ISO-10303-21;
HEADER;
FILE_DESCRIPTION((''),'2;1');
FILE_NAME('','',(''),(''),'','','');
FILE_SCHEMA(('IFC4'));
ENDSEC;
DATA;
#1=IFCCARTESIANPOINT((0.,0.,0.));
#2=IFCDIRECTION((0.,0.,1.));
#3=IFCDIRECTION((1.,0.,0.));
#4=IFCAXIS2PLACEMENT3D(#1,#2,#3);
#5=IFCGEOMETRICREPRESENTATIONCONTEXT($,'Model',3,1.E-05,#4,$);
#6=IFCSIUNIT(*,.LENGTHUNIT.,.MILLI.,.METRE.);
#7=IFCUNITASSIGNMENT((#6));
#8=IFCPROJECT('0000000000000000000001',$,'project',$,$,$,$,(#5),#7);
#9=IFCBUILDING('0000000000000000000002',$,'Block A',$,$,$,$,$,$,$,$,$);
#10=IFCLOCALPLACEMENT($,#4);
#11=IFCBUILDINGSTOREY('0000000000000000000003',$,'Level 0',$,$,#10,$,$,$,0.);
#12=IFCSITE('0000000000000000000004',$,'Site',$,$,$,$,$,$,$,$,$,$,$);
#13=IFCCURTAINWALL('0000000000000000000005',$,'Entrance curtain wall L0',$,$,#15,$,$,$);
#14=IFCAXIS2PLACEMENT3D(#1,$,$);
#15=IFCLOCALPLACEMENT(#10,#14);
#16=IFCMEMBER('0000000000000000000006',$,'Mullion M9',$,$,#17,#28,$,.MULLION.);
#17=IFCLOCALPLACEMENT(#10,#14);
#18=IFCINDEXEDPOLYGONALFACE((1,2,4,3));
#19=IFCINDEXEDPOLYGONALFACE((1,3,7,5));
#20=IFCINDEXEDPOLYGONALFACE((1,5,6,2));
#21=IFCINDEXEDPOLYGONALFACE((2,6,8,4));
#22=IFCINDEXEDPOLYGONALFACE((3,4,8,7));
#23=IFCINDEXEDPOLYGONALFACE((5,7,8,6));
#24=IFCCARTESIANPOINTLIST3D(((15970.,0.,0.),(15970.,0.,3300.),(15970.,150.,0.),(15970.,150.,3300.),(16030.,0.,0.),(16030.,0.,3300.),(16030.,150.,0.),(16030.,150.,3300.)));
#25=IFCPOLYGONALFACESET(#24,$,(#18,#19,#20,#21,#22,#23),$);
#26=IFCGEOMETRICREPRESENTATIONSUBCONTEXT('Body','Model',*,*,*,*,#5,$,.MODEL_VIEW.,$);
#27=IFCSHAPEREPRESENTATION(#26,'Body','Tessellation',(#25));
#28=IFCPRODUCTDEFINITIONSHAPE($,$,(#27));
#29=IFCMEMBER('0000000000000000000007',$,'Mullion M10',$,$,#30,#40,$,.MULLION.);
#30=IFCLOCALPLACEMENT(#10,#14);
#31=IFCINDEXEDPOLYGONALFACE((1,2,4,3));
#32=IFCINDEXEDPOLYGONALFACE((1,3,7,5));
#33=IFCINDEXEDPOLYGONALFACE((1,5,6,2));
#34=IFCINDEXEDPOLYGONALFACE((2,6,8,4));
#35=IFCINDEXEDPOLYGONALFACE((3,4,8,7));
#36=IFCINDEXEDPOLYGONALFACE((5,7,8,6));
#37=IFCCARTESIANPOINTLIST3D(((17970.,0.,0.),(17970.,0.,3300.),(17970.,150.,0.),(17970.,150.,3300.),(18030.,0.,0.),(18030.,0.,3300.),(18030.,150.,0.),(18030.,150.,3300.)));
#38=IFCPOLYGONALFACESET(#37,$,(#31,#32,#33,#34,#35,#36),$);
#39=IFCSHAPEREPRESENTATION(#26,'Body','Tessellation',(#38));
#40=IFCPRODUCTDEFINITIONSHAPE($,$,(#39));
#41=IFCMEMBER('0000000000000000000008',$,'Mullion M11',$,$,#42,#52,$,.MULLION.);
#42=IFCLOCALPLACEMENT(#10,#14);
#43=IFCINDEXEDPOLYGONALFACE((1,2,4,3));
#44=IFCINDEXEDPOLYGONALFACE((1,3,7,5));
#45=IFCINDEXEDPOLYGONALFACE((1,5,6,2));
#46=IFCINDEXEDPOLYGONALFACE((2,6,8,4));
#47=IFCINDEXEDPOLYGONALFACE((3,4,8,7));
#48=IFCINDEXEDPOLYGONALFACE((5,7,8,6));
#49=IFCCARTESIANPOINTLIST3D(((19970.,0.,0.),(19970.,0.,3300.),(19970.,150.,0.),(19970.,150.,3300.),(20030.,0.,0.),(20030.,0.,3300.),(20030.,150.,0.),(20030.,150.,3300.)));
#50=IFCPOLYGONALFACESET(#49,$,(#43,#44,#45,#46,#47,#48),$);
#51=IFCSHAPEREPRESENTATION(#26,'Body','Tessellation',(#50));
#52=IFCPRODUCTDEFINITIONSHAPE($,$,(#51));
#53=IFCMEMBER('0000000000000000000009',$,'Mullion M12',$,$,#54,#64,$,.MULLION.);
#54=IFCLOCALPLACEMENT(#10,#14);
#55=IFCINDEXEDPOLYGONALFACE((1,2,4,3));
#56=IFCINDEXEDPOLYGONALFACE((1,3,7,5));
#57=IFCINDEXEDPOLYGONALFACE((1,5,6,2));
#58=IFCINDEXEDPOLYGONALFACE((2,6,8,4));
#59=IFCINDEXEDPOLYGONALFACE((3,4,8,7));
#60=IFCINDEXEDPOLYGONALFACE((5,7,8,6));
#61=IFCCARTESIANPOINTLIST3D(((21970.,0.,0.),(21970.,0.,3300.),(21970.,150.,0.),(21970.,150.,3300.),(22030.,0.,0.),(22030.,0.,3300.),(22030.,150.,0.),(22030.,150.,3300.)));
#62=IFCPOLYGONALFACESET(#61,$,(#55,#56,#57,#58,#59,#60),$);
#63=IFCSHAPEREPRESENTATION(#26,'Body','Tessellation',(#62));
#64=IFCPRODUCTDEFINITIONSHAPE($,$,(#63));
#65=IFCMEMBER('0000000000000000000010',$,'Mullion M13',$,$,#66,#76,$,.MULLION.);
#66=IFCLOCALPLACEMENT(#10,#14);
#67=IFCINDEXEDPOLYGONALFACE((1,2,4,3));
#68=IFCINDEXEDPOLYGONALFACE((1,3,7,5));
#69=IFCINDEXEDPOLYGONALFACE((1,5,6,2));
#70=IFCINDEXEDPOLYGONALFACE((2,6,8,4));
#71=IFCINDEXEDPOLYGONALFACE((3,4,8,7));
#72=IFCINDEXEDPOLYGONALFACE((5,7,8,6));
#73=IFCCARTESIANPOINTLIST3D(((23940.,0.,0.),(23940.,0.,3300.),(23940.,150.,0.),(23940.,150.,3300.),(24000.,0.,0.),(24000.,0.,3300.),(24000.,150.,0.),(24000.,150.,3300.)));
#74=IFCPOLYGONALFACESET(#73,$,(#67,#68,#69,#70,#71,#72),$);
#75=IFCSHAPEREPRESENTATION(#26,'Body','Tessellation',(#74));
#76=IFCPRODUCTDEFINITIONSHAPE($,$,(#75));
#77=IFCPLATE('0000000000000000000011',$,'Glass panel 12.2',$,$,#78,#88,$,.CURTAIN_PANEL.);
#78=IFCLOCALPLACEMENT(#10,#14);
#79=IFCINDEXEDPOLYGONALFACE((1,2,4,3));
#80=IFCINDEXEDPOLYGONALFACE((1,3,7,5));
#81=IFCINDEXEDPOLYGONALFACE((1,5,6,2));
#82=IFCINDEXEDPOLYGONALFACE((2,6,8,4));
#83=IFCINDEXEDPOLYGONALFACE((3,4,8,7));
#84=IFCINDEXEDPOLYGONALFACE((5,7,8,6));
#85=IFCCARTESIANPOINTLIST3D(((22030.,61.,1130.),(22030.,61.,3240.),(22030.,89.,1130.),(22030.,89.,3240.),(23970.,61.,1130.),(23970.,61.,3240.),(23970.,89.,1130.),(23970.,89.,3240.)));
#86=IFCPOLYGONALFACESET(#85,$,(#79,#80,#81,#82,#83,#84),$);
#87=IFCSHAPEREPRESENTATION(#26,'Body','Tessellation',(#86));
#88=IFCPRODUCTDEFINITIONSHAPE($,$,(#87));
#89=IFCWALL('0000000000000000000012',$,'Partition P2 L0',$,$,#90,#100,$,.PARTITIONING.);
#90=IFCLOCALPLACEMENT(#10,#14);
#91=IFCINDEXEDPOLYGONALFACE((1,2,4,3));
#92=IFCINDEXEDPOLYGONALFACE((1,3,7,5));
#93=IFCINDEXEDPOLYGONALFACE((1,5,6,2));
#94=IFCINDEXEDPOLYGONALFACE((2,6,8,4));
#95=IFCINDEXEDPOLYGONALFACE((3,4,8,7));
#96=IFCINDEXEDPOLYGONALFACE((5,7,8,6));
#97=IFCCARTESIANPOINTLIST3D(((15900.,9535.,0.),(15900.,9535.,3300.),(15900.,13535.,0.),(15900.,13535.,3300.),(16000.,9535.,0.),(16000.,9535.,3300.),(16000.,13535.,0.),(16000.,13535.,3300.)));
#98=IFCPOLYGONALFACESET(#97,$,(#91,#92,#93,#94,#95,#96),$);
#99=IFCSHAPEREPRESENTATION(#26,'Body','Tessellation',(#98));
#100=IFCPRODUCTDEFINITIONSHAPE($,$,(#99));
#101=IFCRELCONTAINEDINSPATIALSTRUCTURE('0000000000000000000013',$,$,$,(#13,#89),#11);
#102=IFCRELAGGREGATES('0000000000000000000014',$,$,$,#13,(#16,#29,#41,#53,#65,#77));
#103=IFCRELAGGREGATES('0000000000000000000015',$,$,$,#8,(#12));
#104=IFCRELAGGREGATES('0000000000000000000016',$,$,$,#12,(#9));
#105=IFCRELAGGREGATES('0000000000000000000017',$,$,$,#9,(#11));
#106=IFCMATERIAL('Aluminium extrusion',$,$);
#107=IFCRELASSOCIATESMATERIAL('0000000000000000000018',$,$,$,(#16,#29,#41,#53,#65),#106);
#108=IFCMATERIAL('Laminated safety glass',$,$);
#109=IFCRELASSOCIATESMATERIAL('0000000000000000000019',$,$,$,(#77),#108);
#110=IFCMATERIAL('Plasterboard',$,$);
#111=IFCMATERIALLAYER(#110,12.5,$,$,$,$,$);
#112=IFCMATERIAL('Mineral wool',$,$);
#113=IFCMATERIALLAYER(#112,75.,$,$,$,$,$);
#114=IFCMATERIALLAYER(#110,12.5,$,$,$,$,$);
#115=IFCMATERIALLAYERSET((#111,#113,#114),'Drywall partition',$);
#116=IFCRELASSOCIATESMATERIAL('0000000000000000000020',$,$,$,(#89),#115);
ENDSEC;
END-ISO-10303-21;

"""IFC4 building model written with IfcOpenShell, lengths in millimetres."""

from ifc_helpers import new_model, si_unit, frame, origin_with_axes, place, context, subcontext, project, spatial, indexed_curve, rectangle, outline, extrude, material, layer, layer_set, layer_usage, element, aggregate, save


model = new_model("IFC4")

# Units and contexts
model_context = context("Model", 3, precision=1e-05, world=origin_with_axes())
body_context = subcontext(model_context, "Body", "Model", "MODEL_VIEW")
ifc_project = project(units=[si_unit("LENGTHUNIT", "METRE", prefix="MILLI")], contexts=[model_context])

# Site, building, storey
site = spatial("IfcSite", under=ifc_project, Name="Site")
building = spatial("IfcBuilding", under=site, Name="Block A")
storey_placement = place(None, origin_with_axes())
storey = spatial("IfcBuildingStorey", under=building, at=storey_placement, Name="Level 0", Elevation=0.0)

# Curtain wall, members, plate
curtain_wall_placement = place(storey_placement, origin_with_axes())
curtain_wall = element("IfcCurtainWall", 1, at=curtain_wall_placement, inside=storey, Name="Entrance curtain wall L0")
ifc_material_1 = material(Name="Aluminium extrusion")
member_1_placement = place(curtain_wall_placement, frame((16000.0, 75.0, 0.0), z_axis=(0.0, 0.0, 1.0), x_axis=(1.0, 0.0, 0.0)))
member_1 = element("IfcMember", 2, at=member_1_placement, material=ifc_material_1, Name="Mullion M9", PredefinedType="MULLION", context=body_context, shape_type="SweptSolid", body=[
    extrude(rectangle(XDim=60.0, YDim=150.0), origin_with_axes(), (0.0, 0.0, 1.0), 3300.0),
])
member_2_placement = place(curtain_wall_placement, frame((18000.0, 75.0, 0.0), z_axis=(0.0, 0.0, 1.0), x_axis=(1.0, 0.0, 0.0)))
member_2 = element("IfcMember", 3, at=member_2_placement, material=ifc_material_1, Name="Mullion M10", PredefinedType="MULLION", context=body_context, shape_type="SweptSolid", body=[
    extrude(rectangle(XDim=60.0, YDim=150.0), origin_with_axes(), (0.0, 0.0, 1.0), 3300.0),
])
member_3_placement = place(curtain_wall_placement, frame((20000.0, 75.0, 0.0), z_axis=(0.0, 0.0, 1.0), x_axis=(1.0, 0.0, 0.0)))
member_3 = element("IfcMember", 4, at=member_3_placement, material=ifc_material_1, Name="Mullion M11", PredefinedType="MULLION", context=body_context, shape_type="SweptSolid", body=[
    extrude(rectangle(XDim=60.0, YDim=150.0), origin_with_axes(), (0.0, 0.0, 1.0), 3300.0),
])
member_4_placement = place(curtain_wall_placement, frame((22000.0, 75.0, 0.0), z_axis=(0.0, 0.0, 1.0), x_axis=(1.0, 0.0, 0.0)))
member_4 = element("IfcMember", 5, at=member_4_placement, material=ifc_material_1, Name="Mullion M12", PredefinedType="MULLION", context=body_context, shape_type="SweptSolid", body=[
    extrude(rectangle(XDim=60.0, YDim=150.0), origin_with_axes(), (0.0, 0.0, 1.0), 3300.0),
])
member_5_placement = place(curtain_wall_placement, frame((23970.0, 75.0, 0.0), z_axis=(0.0, 0.0, 1.0), x_axis=(1.0, 0.0, 0.0)))
member_5 = element("IfcMember", 6, at=member_5_placement, material=ifc_material_1, Name="Mullion M13", PredefinedType="MULLION", context=body_context, shape_type="SweptSolid", body=[
    extrude(rectangle(XDim=60.0, YDim=150.0), origin_with_axes(), (0.0, 0.0, 1.0), 3300.0),
])
ifc_material_2 = material(Name="Laminated safety glass")
plate_placement = place(curtain_wall_placement, frame((22030.0, 61.0, 1130.0), z_axis=(0.0, 0.0, 1.0), x_axis=(1.0, 0.0, 0.0)))
plate = element("IfcPlate", 7, at=plate_placement, material=ifc_material_2, Name="Glass panel 12.2", PredefinedType="CURTAIN_PANEL", context=body_context, shape_type="SweptSolid", body=[
    extrude(outline(indexed_curve([(0.0, 0.0), (0.0, 28.0), (1940.0, 28.0), (1940.0, 0.0), (0.0, 0.0)], self_intersect=False)), origin_with_axes(), (0.0, 0.0, 1.0), 2110.0),
])
aggregate(curtain_wall, [member_1, member_2, member_3, member_4, member_5, plate])

# Shared definitions
ifc_material_3 = material(Name="Mineral wool")

# Wall
ifc_material_4 = material(Name="Plasterboard")
ifc_layer_1 = layer(ifc_material_4, 12.5)
ifc_layer_2 = layer(ifc_material_3, 75.0)
ifc_layer_3 = layer(ifc_material_4, 12.5)
ifc_layer_set_1 = layer_set([ifc_layer_1, ifc_layer_2, ifc_layer_3], Name="Drywall partition")
ifc_layer_usage_1 = layer_usage(ifc_layer_set_1, "AXIS2", "POSITIVE", 0.0)
wall_1_placement = place(storey_placement, frame((16000.0, 9535.0, 0.0), z_axis=(0.0, 0.0, 1.0), x_axis=(0.0, 1.0, 0.0)))
element("IfcWall", 8, at=wall_1_placement, inside=storey, material=ifc_layer_usage_1, Name="Partition P2 L0", PredefinedType="PARTITIONING", context=body_context, shape_type="SweptSolid", body=[
    extrude(outline(indexed_curve([(0.0, 0.0), (0.0, 100.0), (4000.0, 100.0), (4000.0, 0.0), (0.0, 0.0)], self_intersect=False)), origin_with_axes(), (0.0, 0.0, 1.0), 3300.0),
])

save(model, "model.ifc")
